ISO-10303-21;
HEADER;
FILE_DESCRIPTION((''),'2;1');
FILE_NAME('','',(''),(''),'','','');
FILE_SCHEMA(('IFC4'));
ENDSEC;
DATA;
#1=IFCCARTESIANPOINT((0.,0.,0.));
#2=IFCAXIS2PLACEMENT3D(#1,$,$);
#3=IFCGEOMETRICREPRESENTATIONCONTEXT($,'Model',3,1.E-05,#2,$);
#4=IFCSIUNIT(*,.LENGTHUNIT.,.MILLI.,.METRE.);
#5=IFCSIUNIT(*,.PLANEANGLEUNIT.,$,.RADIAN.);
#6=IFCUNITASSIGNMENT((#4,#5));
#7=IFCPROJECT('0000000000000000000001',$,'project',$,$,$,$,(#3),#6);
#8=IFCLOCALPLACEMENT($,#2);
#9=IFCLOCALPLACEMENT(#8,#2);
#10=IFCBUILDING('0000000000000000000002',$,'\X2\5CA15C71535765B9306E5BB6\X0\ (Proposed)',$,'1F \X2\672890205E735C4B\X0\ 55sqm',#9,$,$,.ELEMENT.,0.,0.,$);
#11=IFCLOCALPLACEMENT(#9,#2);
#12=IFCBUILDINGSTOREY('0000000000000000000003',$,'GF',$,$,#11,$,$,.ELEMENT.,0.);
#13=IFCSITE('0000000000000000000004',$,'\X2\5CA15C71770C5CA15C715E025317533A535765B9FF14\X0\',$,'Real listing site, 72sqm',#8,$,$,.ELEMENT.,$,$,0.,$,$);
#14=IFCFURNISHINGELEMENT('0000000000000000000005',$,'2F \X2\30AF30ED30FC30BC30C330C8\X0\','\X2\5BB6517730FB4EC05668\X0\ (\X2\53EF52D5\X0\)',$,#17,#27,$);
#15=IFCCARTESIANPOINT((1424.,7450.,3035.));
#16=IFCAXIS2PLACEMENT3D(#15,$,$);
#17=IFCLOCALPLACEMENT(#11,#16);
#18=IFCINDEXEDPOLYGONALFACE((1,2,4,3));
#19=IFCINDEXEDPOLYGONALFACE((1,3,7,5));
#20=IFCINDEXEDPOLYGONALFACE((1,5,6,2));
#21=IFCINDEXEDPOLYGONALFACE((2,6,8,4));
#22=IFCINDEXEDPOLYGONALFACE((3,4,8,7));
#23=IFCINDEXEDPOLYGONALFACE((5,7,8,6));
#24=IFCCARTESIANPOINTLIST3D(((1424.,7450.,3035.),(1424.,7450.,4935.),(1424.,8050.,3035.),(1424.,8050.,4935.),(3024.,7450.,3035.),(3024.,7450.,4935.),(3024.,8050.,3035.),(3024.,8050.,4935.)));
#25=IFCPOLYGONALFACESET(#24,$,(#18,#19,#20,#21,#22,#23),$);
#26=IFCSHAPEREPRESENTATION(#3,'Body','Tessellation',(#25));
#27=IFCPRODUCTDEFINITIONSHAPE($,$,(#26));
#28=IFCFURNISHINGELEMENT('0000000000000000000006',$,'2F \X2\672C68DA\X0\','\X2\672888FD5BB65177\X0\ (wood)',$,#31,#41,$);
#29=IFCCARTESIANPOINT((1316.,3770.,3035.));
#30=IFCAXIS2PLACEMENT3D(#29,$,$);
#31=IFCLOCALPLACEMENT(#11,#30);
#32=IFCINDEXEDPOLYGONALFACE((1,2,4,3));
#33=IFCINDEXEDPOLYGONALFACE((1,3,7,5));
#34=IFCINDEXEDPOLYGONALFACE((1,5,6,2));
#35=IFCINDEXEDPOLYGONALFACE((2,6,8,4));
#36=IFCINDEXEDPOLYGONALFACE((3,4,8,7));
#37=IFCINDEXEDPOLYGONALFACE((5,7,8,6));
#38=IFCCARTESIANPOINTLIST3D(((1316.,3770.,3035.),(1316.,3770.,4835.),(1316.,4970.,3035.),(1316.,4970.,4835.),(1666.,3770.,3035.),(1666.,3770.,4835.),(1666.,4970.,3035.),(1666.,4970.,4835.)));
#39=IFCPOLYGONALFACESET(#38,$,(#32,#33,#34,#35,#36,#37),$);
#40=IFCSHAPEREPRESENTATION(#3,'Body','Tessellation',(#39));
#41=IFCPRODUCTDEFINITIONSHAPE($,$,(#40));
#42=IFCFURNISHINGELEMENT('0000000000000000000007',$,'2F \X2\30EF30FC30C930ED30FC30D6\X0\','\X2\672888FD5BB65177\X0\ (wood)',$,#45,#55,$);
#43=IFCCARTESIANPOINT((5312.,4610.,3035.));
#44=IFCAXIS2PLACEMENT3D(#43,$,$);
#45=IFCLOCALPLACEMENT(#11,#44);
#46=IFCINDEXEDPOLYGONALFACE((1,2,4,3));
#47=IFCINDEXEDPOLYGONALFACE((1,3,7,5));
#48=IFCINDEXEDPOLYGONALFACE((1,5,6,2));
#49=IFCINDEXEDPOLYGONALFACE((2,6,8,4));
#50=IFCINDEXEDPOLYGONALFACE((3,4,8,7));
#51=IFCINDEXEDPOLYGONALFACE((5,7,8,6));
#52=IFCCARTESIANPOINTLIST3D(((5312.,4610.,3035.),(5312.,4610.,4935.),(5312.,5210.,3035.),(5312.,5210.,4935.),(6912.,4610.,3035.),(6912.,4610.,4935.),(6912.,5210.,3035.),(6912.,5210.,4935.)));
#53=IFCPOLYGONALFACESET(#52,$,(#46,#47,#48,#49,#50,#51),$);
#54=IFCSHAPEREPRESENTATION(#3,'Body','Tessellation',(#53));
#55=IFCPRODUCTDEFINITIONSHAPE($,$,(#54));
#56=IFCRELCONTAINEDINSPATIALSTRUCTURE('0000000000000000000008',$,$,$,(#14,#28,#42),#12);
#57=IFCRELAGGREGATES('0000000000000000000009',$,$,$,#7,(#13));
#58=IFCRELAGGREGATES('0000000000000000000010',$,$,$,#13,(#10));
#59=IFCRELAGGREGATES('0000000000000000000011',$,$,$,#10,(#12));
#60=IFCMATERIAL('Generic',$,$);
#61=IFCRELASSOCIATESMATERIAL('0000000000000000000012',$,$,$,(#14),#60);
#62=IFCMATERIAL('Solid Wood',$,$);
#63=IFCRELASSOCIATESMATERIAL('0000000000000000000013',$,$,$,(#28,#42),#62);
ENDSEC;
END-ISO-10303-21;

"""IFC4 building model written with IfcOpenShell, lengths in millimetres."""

from ifc_helpers import new_model, si_unit, frame, frame_2d, origin, place, context, project, spatial, rectangle, extrude, material, element, save


model = new_model("IFC4")

# Units and contexts
model_context = context("Model", 3, precision=1e-05, world=origin())
ifc_project = project(units=[si_unit("LENGTHUNIT", "METRE", prefix="MILLI"), si_unit("PLANEANGLEUNIT", "RADIAN")], contexts=[model_context])

# Site, building, storey
site_placement = place(None, origin())
site = spatial("IfcSite", under=ifc_project, at=site_placement, Name="岡山県岡山市北区南方４", ObjectType="Real listing site, 72sqm", CompositionType="ELEMENT", RefElevation=0.0)
building_placement = place(site_placement, origin())
building = spatial("IfcBuilding", under=site, at=building_placement, Name="岡山南方の家 (Proposed)", ObjectType="1F 木造平屋 55sqm", CompositionType="ELEMENT", ElevationOfRefHeight=0.0, ElevationOfTerrain=0.0)
storey_placement = place(building_placement, origin())
storey = spatial("IfcBuildingStorey", under=building, at=storey_placement, Name="GF", CompositionType="ELEMENT", Elevation=0.0)

# Shared definitions
ifc_material_1 = material(Name="Solid Wood")

# Shared definitions
ifc_material_2 = material(Name="Generic")

# Furnishing elements
furnishing_1_placement = place(storey_placement, frame((1424.0, 7450.0, 3035.0)))
element("IfcFurnishingElement", 1, at=furnishing_1_placement, inside=storey, material=ifc_material_2, Name="2F クローゼット", Description="家具・什器 (可動)", context=model_context, shape_type="SweptSolid", body=[
    extrude(rectangle(XDim=1600.0, YDim=600.0, at=frame_2d((800.0, 300.0))), frame((1424.0, 7450.0, 3035.0)), (0.0, 0.0, 1.0), 1900.0),
])
furnishing_2_placement = place(storey_placement, frame((1316.0, 3770.0, 3035.0)))
element("IfcFurnishingElement", 2, at=furnishing_2_placement, inside=storey, material=ifc_material_1, Name="2F 本棚", Description="木製家具 (wood)", context=model_context, shape_type="SweptSolid", body=[
    extrude(rectangle(XDim=350.0, YDim=1200.0, at=frame_2d((175.0, 600.0))), frame((1316.0, 3770.0, 3035.0)), (0.0, 0.0, 1.0), 1800.0),
])
furnishing_3_placement = place(storey_placement, frame((5312.0, 4610.0, 3035.0)))
element("IfcFurnishingElement", 3, at=furnishing_3_placement, inside=storey, material=ifc_material_1, Name="2F ワードローブ", Description="木製家具 (wood)", context=model_context, shape_type="SweptSolid", body=[
    extrude(rectangle(XDim=1600.0, YDim=600.0, at=frame_2d((800.0, 300.0))), frame((5312.0, 4610.0, 3035.0)), (0.0, 0.0, 1.0), 1900.0),
])

save(model, "model.ifc")
